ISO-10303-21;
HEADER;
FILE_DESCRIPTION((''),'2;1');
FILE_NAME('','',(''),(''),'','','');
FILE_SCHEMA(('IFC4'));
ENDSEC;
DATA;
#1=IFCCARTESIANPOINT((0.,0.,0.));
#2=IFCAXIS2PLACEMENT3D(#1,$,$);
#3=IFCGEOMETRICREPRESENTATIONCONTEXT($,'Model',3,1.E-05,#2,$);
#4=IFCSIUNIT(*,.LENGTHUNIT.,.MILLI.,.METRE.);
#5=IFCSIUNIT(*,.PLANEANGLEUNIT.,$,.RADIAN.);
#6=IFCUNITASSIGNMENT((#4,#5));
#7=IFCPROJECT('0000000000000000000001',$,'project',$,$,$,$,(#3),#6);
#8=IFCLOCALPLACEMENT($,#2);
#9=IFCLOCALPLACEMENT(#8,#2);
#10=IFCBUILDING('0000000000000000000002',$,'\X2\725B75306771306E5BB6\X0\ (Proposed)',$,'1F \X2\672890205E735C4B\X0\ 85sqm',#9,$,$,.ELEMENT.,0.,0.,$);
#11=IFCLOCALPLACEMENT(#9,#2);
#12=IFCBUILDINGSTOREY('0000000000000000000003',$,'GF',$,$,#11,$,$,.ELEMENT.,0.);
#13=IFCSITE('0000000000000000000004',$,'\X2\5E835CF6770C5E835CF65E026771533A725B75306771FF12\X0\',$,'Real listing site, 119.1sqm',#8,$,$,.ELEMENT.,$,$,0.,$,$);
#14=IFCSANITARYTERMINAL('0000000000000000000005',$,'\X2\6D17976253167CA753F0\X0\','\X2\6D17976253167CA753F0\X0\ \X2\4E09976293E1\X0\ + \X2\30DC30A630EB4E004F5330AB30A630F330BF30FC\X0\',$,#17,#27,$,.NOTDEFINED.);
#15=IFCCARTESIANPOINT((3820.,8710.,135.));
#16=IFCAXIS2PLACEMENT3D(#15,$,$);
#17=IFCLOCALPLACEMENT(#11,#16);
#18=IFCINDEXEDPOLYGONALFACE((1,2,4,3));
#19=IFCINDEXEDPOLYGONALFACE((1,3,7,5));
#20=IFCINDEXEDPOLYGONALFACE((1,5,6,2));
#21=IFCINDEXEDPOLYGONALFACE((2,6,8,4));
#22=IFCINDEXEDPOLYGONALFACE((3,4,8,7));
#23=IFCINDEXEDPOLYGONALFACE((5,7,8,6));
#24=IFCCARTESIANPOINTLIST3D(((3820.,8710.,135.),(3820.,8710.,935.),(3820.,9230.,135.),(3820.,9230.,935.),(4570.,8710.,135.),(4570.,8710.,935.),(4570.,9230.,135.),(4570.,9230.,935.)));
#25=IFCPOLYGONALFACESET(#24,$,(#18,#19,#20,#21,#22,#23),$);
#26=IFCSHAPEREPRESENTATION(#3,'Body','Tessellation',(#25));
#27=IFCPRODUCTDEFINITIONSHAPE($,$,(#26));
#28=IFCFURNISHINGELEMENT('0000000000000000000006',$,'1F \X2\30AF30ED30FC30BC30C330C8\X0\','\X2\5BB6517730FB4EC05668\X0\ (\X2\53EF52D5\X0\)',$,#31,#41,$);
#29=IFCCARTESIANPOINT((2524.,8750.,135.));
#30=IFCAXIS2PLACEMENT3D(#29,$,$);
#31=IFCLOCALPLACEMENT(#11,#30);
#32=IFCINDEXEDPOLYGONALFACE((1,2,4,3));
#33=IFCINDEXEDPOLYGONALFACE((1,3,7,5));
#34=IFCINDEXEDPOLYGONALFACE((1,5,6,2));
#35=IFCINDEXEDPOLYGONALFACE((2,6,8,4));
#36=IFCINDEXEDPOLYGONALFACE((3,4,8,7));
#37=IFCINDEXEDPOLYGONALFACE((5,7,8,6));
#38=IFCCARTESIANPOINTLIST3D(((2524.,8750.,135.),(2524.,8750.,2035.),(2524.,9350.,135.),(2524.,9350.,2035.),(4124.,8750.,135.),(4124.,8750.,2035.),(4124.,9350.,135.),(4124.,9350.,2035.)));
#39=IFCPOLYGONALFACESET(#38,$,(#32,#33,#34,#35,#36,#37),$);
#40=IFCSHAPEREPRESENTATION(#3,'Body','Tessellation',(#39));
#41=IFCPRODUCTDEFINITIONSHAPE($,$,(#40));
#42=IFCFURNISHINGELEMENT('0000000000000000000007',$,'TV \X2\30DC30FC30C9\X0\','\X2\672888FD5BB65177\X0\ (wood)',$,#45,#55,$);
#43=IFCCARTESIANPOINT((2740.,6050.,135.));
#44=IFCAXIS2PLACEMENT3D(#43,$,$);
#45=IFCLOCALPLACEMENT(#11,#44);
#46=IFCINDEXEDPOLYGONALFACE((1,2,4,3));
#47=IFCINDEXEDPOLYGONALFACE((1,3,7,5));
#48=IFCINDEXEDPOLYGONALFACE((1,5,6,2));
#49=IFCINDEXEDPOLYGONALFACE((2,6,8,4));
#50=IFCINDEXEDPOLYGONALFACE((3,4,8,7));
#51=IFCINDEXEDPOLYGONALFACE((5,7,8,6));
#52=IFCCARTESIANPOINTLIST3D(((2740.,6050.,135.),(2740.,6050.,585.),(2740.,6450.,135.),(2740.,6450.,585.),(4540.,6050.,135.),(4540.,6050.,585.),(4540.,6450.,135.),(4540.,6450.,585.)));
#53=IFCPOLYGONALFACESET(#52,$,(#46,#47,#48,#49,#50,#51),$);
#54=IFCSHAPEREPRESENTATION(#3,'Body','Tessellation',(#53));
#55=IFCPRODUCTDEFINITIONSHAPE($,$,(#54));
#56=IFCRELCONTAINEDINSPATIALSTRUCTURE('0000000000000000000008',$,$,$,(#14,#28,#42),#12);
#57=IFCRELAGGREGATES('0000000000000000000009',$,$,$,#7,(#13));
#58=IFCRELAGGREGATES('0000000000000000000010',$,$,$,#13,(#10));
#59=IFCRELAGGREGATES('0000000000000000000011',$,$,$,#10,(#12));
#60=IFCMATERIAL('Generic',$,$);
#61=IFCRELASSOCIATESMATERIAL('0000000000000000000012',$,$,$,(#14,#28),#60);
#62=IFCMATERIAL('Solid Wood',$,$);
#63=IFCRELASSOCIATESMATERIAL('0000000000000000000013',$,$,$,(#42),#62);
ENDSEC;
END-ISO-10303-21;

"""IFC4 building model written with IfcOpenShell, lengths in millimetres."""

from ifc_helpers import new_model, si_unit, frame, frame_2d, origin, place, context, project, spatial, rectangle, extrude, material, element, save


model = new_model("IFC4")

# Units and contexts
model_context = context("Model", 3, precision=1e-05, world=origin())
ifc_project = project(units=[si_unit("LENGTHUNIT", "METRE", prefix="MILLI"), si_unit("PLANEANGLEUNIT", "RADIAN")], contexts=[model_context])

# Site, building, storey
site_placement = place(None, origin())
site = spatial("IfcSite", under=ifc_project, at=site_placement, Name="広島県広島市東区牛田東２", ObjectType="Real listing site, 119.1sqm", CompositionType="ELEMENT", RefElevation=0.0)
building_placement = place(site_placement, origin())
building = spatial("IfcBuilding", under=site, at=building_placement, Name="牛田東の家 (Proposed)", ObjectType="1F 木造平屋 85sqm", CompositionType="ELEMENT", ElevationOfRefHeight=0.0, ElevationOfTerrain=0.0)
storey_placement = place(building_placement, origin())
storey = spatial("IfcBuildingStorey", under=building, at=storey_placement, Name="GF", CompositionType="ELEMENT", Elevation=0.0)

# Shared definitions
ifc_material_1 = material(Name="Solid Wood")

# Shared definitions
ifc_material_2 = material(Name="Generic")

# Sanitary terminal
sanitary_terminal_1_placement = place(storey_placement, frame((3820.0, 8710.0, 135.0)))
element("IfcSanitaryTerminal", 1, at=sanitary_terminal_1_placement, inside=storey, material=ifc_material_2, Name="洗面化粧台", Description="洗面化粧台 三面鏡 + ボウル一体カウンター", PredefinedType="NOTDEFINED", context=model_context, shape_type="SweptSolid", body=[
    extrude(rectangle(XDim=750.0, YDim=520.0, at=frame_2d((375.0, 260.0))), frame((3820.0, 8710.0, 135.0)), (0.0, 0.0, 1.0), 800.0),
])

# Furnishing elements
furnishing_1_placement = place(storey_placement, frame((2524.0, 8750.0, 135.0)))
element("IfcFurnishingElement", 2, at=furnishing_1_placement, inside=storey, material=ifc_material_2, Name="1F クローゼット", Description="家具・什器 (可動)", context=model_context, shape_type="SweptSolid", body=[
    extrude(rectangle(XDim=1600.0, YDim=600.0, at=frame_2d((800.0, 300.0))), frame((2524.0, 8750.0, 135.0)), (0.0, 0.0, 1.0), 1900.0),
])
furnishing_2_placement = place(storey_placement, frame((2740.0, 6050.0, 135.0)))
element("IfcFurnishingElement", 3, at=furnishing_2_placement, inside=storey, material=ifc_material_1, Name="TV ボード", Description="木製家具 (wood)", context=model_context, shape_type="SweptSolid", body=[
    extrude(rectangle(XDim=1800.0, YDim=400.0, at=frame_2d((900.0, 200.0))), frame((2740.0, 6050.0, 135.0)), (0.0, 0.0, 1.0), 450.0),
])

save(model, "model.ifc")
